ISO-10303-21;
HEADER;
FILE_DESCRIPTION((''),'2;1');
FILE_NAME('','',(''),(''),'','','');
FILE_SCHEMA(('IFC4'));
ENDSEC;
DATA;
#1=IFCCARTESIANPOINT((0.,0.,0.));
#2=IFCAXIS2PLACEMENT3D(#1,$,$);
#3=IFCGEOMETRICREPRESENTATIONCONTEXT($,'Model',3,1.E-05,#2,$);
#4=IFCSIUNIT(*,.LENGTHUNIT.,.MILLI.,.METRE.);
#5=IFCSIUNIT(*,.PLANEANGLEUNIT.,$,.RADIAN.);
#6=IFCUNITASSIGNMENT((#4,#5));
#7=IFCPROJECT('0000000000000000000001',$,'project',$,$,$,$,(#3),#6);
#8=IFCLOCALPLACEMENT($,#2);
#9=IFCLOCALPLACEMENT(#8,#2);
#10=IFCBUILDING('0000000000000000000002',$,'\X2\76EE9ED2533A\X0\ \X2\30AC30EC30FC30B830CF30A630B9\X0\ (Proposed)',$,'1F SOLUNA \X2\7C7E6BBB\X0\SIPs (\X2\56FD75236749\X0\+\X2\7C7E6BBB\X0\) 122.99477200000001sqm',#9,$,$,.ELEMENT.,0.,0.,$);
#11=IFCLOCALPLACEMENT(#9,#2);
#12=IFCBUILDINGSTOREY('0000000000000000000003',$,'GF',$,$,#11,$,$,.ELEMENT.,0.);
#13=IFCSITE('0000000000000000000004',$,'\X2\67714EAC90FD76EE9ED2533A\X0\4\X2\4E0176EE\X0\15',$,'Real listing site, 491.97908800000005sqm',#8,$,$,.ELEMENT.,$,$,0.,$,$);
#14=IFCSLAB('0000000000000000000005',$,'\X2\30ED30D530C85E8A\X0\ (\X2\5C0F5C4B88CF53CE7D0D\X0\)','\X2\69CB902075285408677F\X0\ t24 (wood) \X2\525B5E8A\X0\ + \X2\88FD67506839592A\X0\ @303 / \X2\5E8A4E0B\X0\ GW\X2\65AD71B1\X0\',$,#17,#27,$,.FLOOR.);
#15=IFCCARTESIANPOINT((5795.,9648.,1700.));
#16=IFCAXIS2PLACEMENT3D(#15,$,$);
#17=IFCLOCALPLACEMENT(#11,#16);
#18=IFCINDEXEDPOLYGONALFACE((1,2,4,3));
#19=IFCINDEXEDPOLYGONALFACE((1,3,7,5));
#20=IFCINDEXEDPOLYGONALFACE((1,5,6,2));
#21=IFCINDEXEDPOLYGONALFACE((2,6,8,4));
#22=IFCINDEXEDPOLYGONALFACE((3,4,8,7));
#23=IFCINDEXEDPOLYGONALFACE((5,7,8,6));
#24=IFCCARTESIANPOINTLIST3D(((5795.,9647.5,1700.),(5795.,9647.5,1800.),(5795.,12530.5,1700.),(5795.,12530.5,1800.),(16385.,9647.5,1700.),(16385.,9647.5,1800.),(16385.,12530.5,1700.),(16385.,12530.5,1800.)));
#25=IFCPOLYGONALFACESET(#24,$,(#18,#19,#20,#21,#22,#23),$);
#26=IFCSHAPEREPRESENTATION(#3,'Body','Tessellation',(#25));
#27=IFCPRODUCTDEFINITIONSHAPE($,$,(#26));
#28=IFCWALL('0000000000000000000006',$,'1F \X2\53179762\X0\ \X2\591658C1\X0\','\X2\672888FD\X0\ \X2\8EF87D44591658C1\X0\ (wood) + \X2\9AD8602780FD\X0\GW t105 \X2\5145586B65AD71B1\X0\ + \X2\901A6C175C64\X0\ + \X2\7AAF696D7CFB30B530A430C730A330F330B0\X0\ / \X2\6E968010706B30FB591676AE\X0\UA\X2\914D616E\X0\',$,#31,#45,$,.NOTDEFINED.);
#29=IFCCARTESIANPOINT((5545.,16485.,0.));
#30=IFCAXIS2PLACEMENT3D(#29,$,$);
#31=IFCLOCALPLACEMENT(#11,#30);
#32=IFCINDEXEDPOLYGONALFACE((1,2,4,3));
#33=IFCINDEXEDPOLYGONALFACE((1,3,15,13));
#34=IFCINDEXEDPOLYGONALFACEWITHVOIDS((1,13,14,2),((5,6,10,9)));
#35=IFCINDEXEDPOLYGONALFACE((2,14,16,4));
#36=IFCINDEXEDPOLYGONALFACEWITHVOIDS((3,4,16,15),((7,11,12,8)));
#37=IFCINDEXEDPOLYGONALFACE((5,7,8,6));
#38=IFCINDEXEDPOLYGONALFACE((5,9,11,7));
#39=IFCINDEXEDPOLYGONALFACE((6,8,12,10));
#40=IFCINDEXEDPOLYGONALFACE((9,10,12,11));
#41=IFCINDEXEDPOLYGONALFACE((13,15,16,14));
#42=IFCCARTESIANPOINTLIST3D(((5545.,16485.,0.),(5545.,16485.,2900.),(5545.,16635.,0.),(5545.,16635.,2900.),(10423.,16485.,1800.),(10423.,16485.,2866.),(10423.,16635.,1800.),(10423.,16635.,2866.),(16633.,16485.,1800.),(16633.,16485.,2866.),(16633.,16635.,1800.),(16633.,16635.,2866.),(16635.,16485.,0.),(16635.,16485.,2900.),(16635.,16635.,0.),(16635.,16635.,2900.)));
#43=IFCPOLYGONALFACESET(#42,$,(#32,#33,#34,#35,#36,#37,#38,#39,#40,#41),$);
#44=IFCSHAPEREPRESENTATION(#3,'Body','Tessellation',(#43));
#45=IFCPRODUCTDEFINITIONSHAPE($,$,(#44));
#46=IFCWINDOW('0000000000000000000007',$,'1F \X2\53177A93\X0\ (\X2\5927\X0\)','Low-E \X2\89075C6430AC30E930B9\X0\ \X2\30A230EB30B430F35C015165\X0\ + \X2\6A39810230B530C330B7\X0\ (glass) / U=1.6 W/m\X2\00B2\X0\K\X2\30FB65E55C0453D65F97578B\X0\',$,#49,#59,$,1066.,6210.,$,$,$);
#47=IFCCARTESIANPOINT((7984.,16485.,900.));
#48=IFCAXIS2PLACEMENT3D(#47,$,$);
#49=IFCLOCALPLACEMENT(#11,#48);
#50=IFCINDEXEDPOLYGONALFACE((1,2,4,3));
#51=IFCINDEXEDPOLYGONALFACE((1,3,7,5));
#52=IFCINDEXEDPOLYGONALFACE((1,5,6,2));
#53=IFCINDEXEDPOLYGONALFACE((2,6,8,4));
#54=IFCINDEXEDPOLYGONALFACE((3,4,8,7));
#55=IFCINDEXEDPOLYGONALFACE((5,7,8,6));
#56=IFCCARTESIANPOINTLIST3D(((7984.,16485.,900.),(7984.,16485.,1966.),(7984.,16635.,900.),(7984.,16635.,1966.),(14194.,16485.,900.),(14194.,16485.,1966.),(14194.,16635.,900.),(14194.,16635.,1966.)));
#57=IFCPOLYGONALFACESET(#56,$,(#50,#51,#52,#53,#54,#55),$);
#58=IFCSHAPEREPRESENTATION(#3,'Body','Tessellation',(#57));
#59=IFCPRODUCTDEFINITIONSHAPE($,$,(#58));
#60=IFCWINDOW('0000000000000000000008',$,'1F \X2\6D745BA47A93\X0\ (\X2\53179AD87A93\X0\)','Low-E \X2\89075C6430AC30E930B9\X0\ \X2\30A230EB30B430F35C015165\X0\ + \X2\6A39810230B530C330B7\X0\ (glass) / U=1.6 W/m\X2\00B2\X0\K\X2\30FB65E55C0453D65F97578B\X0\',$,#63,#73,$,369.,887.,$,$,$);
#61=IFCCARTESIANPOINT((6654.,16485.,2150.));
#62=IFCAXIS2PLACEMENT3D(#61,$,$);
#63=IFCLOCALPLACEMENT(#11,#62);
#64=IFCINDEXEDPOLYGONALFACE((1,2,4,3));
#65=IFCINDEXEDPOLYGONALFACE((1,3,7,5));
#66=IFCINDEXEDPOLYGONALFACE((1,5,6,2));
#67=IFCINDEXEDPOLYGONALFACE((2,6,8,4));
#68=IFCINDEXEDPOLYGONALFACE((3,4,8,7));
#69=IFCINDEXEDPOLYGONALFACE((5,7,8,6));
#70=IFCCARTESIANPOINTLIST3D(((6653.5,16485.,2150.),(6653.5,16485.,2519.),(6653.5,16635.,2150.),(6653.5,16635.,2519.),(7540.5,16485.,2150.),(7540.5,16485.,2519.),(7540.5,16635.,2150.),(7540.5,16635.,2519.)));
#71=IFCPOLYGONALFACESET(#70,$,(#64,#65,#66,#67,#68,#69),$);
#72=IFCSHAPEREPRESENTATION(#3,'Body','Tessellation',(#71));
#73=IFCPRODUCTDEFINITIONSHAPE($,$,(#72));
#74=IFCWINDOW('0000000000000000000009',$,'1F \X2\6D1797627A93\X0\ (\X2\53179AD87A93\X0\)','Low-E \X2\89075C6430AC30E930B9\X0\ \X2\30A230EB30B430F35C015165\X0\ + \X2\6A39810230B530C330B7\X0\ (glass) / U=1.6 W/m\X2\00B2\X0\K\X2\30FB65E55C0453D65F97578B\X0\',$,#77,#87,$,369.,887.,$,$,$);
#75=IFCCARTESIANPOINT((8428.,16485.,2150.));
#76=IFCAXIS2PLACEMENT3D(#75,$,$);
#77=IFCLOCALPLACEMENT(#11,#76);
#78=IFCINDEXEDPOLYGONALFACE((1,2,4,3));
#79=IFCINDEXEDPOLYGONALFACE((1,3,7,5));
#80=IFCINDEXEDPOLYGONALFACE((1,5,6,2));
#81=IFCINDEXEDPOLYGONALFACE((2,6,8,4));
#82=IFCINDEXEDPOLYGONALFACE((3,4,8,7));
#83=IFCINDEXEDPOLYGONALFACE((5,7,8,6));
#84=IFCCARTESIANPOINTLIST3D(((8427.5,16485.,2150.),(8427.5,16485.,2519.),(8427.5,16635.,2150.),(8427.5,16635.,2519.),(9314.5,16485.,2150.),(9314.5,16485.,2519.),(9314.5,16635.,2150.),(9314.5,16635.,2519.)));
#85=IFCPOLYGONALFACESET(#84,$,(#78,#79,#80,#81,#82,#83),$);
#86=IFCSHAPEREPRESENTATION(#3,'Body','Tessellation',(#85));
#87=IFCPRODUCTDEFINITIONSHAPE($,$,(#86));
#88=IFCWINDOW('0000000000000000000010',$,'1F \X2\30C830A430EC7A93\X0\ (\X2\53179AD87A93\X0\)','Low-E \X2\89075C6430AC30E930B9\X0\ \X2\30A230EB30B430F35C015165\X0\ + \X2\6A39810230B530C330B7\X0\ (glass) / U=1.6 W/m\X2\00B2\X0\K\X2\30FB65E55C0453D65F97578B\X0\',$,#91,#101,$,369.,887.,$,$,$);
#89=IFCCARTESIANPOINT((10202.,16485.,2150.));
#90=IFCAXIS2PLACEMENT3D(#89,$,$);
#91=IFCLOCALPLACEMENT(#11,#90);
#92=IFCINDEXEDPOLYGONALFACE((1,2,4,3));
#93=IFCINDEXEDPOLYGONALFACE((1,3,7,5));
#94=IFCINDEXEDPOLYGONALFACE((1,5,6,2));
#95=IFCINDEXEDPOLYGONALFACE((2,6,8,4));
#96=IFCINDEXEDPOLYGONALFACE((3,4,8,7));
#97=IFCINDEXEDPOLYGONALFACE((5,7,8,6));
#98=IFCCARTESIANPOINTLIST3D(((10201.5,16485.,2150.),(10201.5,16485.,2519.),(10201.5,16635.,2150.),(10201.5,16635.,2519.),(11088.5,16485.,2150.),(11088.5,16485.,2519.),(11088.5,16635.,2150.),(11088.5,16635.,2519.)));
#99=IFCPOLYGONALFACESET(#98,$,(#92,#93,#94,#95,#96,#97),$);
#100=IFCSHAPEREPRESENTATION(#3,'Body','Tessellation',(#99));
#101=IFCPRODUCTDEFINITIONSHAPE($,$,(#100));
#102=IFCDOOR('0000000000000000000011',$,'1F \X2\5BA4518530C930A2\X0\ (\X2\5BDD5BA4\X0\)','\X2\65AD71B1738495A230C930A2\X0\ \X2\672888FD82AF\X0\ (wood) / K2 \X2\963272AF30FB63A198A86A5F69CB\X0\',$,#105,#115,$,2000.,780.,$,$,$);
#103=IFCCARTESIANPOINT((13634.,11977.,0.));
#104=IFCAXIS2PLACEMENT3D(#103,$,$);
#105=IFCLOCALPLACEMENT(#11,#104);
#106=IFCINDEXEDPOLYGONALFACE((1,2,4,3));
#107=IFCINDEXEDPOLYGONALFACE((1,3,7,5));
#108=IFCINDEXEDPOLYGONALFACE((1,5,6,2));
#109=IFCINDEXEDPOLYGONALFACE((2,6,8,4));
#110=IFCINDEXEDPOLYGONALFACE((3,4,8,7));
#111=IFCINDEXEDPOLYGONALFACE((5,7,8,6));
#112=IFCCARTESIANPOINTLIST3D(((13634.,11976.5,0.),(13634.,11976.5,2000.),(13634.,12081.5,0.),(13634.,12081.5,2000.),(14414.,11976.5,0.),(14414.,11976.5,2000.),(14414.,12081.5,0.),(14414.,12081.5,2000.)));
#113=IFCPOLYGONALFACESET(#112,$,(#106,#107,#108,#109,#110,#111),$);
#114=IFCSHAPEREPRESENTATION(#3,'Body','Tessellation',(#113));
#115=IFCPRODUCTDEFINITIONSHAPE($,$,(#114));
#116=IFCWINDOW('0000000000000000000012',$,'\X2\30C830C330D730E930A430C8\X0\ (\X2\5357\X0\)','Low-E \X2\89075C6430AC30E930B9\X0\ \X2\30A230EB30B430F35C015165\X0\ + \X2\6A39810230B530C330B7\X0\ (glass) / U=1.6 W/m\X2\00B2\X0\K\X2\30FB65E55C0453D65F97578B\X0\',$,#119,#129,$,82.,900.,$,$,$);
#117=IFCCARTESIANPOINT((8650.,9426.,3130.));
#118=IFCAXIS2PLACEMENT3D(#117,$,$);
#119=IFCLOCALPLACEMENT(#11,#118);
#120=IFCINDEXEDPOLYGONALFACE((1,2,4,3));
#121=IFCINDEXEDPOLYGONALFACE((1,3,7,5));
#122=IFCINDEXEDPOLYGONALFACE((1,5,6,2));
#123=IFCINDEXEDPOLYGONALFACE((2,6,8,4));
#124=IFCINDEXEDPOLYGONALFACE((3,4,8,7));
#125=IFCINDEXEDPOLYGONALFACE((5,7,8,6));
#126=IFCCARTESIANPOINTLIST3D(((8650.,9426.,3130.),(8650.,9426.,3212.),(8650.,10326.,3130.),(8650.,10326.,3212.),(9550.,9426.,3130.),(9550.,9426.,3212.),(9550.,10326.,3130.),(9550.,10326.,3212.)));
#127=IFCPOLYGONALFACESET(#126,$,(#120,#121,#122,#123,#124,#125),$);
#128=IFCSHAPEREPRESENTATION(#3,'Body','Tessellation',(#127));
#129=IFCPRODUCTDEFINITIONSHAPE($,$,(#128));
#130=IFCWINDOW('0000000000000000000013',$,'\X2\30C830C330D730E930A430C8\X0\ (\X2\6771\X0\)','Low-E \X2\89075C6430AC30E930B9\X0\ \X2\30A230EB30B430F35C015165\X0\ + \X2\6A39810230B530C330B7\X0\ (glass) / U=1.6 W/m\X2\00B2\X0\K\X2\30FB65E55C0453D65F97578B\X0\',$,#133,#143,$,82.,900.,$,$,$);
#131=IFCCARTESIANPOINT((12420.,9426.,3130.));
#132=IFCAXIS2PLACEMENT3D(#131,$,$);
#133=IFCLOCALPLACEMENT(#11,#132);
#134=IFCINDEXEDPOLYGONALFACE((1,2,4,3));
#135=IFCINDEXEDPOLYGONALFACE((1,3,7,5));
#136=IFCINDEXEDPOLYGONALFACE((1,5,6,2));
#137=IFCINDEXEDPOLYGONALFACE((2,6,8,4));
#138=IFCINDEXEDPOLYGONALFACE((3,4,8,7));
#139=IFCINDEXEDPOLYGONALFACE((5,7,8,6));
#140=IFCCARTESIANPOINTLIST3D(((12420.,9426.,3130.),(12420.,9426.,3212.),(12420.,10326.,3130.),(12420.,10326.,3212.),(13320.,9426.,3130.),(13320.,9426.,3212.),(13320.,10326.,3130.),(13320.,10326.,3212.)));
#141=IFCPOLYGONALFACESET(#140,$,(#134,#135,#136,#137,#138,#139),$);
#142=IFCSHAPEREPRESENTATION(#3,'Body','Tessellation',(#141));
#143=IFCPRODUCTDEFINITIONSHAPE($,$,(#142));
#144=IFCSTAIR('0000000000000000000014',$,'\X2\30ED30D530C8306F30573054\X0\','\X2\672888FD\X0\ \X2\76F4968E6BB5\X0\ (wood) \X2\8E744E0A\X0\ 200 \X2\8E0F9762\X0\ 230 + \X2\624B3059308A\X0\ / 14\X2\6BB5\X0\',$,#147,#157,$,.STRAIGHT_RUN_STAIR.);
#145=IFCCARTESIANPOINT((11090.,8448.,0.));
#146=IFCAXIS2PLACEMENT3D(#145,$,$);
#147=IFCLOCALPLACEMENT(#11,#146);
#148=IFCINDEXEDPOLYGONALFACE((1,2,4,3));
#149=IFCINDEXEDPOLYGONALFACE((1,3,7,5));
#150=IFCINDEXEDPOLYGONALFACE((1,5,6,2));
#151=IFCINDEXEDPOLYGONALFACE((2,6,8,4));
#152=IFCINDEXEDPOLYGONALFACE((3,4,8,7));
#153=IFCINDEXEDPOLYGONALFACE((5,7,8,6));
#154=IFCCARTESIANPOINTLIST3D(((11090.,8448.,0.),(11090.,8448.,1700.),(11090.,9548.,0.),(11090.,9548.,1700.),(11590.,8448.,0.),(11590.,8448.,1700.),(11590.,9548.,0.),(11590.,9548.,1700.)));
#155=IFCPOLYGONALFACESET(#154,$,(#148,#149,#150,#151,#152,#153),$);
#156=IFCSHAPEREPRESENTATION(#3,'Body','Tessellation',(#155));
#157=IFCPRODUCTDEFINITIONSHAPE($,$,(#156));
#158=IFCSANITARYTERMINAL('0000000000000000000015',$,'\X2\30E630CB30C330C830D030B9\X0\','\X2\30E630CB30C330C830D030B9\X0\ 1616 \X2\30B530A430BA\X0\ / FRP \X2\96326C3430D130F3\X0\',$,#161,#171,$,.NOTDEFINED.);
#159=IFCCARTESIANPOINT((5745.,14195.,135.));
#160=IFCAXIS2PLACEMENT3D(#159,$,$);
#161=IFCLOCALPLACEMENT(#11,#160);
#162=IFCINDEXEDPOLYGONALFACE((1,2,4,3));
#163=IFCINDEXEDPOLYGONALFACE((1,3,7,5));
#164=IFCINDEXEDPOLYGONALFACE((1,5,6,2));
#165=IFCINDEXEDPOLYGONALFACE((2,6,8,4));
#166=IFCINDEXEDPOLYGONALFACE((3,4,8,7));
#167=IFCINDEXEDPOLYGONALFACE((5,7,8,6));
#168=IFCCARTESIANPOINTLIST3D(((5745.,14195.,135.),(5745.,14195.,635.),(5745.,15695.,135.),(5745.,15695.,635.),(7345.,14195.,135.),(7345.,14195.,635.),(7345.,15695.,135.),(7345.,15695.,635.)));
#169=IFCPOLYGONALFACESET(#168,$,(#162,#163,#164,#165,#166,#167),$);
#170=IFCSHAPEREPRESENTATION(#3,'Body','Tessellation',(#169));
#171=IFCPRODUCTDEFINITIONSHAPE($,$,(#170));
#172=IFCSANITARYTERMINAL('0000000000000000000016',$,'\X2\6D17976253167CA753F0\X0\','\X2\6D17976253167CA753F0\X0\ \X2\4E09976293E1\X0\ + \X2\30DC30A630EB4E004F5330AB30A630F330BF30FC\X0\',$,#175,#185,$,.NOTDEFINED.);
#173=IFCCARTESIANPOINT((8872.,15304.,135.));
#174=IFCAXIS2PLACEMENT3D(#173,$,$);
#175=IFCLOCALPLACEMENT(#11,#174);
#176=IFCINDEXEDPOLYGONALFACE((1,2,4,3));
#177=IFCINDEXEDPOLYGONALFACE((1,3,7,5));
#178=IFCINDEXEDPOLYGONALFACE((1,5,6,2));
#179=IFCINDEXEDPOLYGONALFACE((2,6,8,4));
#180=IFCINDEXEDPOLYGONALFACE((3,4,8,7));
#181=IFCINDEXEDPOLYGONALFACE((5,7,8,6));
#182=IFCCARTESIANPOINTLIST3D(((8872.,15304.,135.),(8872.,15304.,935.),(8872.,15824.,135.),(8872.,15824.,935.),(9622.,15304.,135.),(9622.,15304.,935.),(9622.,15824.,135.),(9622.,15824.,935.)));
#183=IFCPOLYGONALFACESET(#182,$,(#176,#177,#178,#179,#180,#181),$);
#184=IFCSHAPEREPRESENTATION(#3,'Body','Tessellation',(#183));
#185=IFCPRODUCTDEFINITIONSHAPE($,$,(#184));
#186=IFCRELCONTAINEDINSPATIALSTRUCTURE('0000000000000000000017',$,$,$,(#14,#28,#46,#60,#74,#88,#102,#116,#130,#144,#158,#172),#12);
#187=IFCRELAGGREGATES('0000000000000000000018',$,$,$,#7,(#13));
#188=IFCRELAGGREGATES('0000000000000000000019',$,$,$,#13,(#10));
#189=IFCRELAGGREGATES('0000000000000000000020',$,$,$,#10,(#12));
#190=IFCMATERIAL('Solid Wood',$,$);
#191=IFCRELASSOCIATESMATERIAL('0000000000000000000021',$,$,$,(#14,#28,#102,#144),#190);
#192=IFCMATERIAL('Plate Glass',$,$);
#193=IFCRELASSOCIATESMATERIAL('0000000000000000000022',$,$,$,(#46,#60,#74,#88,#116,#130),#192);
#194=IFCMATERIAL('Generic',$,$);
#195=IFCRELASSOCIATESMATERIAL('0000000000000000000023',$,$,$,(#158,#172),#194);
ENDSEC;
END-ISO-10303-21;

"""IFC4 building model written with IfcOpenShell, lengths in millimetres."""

from ifc_helpers import new_model, si_unit, frame, frame_2d, origin, place, context, project, spatial, rectangle, extrude, material, element, fill, save


model = new_model("IFC4")

# Units and contexts
model_context = context("Model", 3, precision=1e-05, world=origin())
ifc_project = project(units=[si_unit("LENGTHUNIT", "METRE", prefix="MILLI"), si_unit("PLANEANGLEUNIT", "RADIAN")], contexts=[model_context])

# Site, building, storey
site_placement = place(None, origin())
site = spatial("IfcSite", under=ifc_project, at=site_placement, Name="東京都目黒区4丁目15", ObjectType="Real listing site, 491.97908800000005sqm", CompositionType="ELEMENT", RefElevation=0.0)
building_placement = place(site_placement, origin())
building = spatial("IfcBuilding", under=site, at=building_placement, Name="目黒区 ガレージハウス (Proposed)", ObjectType="1F SOLUNA 籾殻SIPs (国産杉+籾殻) 122.99477200000001sqm", CompositionType="ELEMENT", ElevationOfRefHeight=0.0, ElevationOfTerrain=0.0)
storey_placement = place(building_placement, origin())
storey = spatial("IfcBuildingStorey", under=building, at=storey_placement, Name="GF", CompositionType="ELEMENT", Elevation=0.0)

# Slab
ifc_material_1 = material(Name="Solid Wood")
slab_placement = place(storey_placement, frame((5795.0, 9648.0, 1700.0)))
element("IfcSlab", 1, at=slab_placement, inside=storey, material=ifc_material_1, Name="ロフト床 (小屋裏収納)", Description="構造用合板 t24 (wood) 剛床 + 製材根太 @303 / 床下 GW断熱", PredefinedType="FLOOR", context=model_context, shape_type="SweptSolid", body=[
    extrude(rectangle(XDim=10590.0, YDim=2883.0, at=frame_2d((5295.0, 1441.0))), frame((5795.0, 9648.0, 1700.0)), (0.0, 0.0, 1.0), 100.0),
])

# Wall, openings, windows
wall_1_placement = place(storey_placement, frame((5545.0, 16485.0, 0.0)))
wall_1 = element("IfcWall", 2, at=wall_1_placement, inside=storey, material=ifc_material_1, Name="1F 北面 外壁", Description="木製 軸組外壁 (wood) + 高性能GW t105 充填断熱 + 通気層 + 窯業系サイディング / 準耐火・外皮UA配慮", PredefinedType="NOTDEFINED", context=model_context, shape_type="SweptSolid", body=[
    extrude(rectangle(XDim=11090.0, YDim=150.0, at=frame_2d((5545.0, 75.0))), frame((5545.0, 16485.0, 0.0)), (0.0, 0.0, 1.0), 2900.0),
])
opening_1_placement = place(storey_placement, frame((7984.0, 16485.0, 900.0)))
opening_1 = element("IfcOpeningElement", 3, at=opening_1_placement, cuts=wall_1, PredefinedType="NOTDEFINED", context=model_context, shape_type="SweptSolid", body=[
    extrude(rectangle(XDim=6210.0, YDim=150.0, at=frame_2d((3105.0, 75.0))), frame((7984.0, 16485.0, 900.0)), (0.0, 0.0, 1.0), 1066.0),
])
opening_2_placement = place(storey_placement, frame((6654.0, 16485.0, 2150.0)))
opening_2 = element("IfcOpeningElement", 4, at=opening_2_placement, cuts=wall_1, PredefinedType="NOTDEFINED", context=model_context, shape_type="SweptSolid", body=[
    extrude(rectangle(XDim=887.0, YDim=150.0, at=frame_2d((443.0, 75.0))), frame((6654.0, 16485.0, 2150.0)), (0.0, 0.0, 1.0), 369.0),
])
opening_3_placement = place(storey_placement, frame((8428.0, 16485.0, 2150.0)))
opening_3 = element("IfcOpeningElement", 5, at=opening_3_placement, cuts=wall_1, PredefinedType="NOTDEFINED", context=model_context, shape_type="SweptSolid", body=[
    extrude(rectangle(XDim=887.0, YDim=150.0, at=frame_2d((443.0, 75.0))), frame((8428.0, 16485.0, 2150.0)), (0.0, 0.0, 1.0), 369.0),
])
opening_4_placement = place(storey_placement, frame((10202.0, 16485.0, 2150.0)))
opening_4 = element("IfcOpeningElement", 6, at=opening_4_placement, cuts=wall_1, PredefinedType="NOTDEFINED", context=model_context, shape_type="SweptSolid", body=[
    extrude(rectangle(XDim=887.0, YDim=150.0, at=frame_2d((443.0, 75.0))), frame((10202.0, 16485.0, 2150.0)), (0.0, 0.0, 1.0), 369.0),
])
ifc_material_2 = material(Name="Plate Glass")
window_1_placement = place(storey_placement, frame((7984.0, 16485.0, 900.0)))
window_1 = element("IfcWindow", 7, at=window_1_placement, inside=storey, material=ifc_material_2, Name="1F 北窓 (大)", Description="Low-E 複層ガラス アルゴン封入 + 樹脂サッシ (glass) / U=1.6 W/m²K・日射取得型", OverallHeight=1066.0, OverallWidth=6210.0, context=model_context, shape_type="SweptSolid", body=[
    extrude(rectangle(XDim=6210.0, YDim=150.0, at=frame_2d((3105.0, 75.0))), frame((7984.0, 16485.0, 900.0)), (0.0, 0.0, 1.0), 1066.0),
])
fill(opening_1, window_1)
window_2_placement = place(storey_placement, frame((6654.0, 16485.0, 2150.0)))
window_2 = element("IfcWindow", 8, at=window_2_placement, inside=storey, material=ifc_material_2, Name="1F 浴室窓 (北高窓)", Description="Low-E 複層ガラス アルゴン封入 + 樹脂サッシ (glass) / U=1.6 W/m²K・日射取得型", OverallHeight=369.0, OverallWidth=887.0, context=model_context, shape_type="SweptSolid", body=[
    extrude(rectangle(XDim=887.0, YDim=150.0, at=frame_2d((443.0, 75.0))), frame((6654.0, 16485.0, 2150.0)), (0.0, 0.0, 1.0), 369.0),
])
fill(opening_2, window_2)
window_3_placement = place(storey_placement, frame((8428.0, 16485.0, 2150.0)))
window_3 = element("IfcWindow", 9, at=window_3_placement, inside=storey, material=ifc_material_2, Name="1F 洗面窓 (北高窓)", Description="Low-E 複層ガラス アルゴン封入 + 樹脂サッシ (glass) / U=1.6 W/m²K・日射取得型", OverallHeight=369.0, OverallWidth=887.0, context=model_context, shape_type="SweptSolid", body=[
    extrude(rectangle(XDim=887.0, YDim=150.0, at=frame_2d((443.0, 75.0))), frame((8428.0, 16485.0, 2150.0)), (0.0, 0.0, 1.0), 369.0),
])
fill(opening_3, window_3)
window_4_placement = place(storey_placement, frame((10202.0, 16485.0, 2150.0)))
window_4 = element("IfcWindow", 10, at=window_4_placement, inside=storey, material=ifc_material_2, Name="1F トイレ窓 (北高窓)", Description="Low-E 複層ガラス アルゴン封入 + 樹脂サッシ (glass) / U=1.6 W/m²K・日射取得型", OverallHeight=369.0, OverallWidth=887.0, context=model_context, shape_type="SweptSolid", body=[
    extrude(rectangle(XDim=887.0, YDim=150.0, at=frame_2d((443.0, 75.0))), frame((10202.0, 16485.0, 2150.0)), (0.0, 0.0, 1.0), 369.0),
])
fill(opening_4, window_4)

# Door
door_1_placement = place(storey_placement, frame((13634.0, 11977.0, 0.0)))
element("IfcDoor", 11, at=door_1_placement, inside=storey, material=ifc_material_1, Name="1F 室内ドア (寝室)", Description="断熱玄関ドア 木製芯 (wood) / K2 防犯・採風機構", OverallHeight=2000.0, OverallWidth=780.0, context=model_context, shape_type="SweptSolid", body=[
    extrude(rectangle(XDim=780.0, YDim=105.0, at=frame_2d((390.0, 52.0))), frame((13634.0, 11977.0, 0.0)), (0.0, 0.0, 1.0), 2000.0),
])

# Windows
window_5_placement = place(storey_placement, frame((8650.0, 9426.0, 3130.0)))
element("IfcWindow", 12, at=window_5_placement, inside=storey, material=ifc_material_2, Name="トップライト (南)", Description="Low-E 複層ガラス アルゴン封入 + 樹脂サッシ (glass) / U=1.6 W/m²K・日射取得型", OverallHeight=82.0, OverallWidth=900.0, context=model_context, shape_type="SweptSolid", body=[
    extrude(rectangle(XDim=900.0, YDim=900.0, at=frame_2d((450.0, 450.0))), frame((8650.0, 9426.0, 3130.0)), (0.0, 0.0, 1.0), 82.0),
])
window_6_placement = place(storey_placement, frame((12420.0, 9426.0, 3130.0)))
element("IfcWindow", 13, at=window_6_placement, inside=storey, material=ifc_material_2, Name="トップライト (東)", Description="Low-E 複層ガラス アルゴン封入 + 樹脂サッシ (glass) / U=1.6 W/m²K・日射取得型", OverallHeight=82.0, OverallWidth=900.0, context=model_context, shape_type="SweptSolid", body=[
    extrude(rectangle(XDim=900.0, YDim=900.0, at=frame_2d((450.0, 450.0))), frame((12420.0, 9426.0, 3130.0)), (0.0, 0.0, 1.0), 82.0),
])

# Stair
stair_placement = place(storey_placement, frame((11090.0, 8448.0, 0.0)))
element("IfcStair", 14, at=stair_placement, inside=storey, material=ifc_material_1, Name="ロフトはしご", Description="木製 直階段 (wood) 蹴上 200 踏面 230 + 手すり / 14段", PredefinedType="STRAIGHT_RUN_STAIR", context=model_context, shape_type="SweptSolid", body=[
    extrude(rectangle(XDim=500.0, YDim=1100.0, at=frame_2d((250.0, 550.0))), frame((11090.0, 8448.0, 0.0)), (0.0, 0.0, 1.0), 1700.0),
])

# Sanitary terminals
ifc_material_3 = material(Name="Generic")
sanitary_terminal_1_placement = place(storey_placement, frame((5745.0, 14195.0, 135.0)))
element("IfcSanitaryTerminal", 15, at=sanitary_terminal_1_placement, inside=storey, material=ifc_material_3, Name="ユニットバス", Description="ユニットバス 1616 サイズ / FRP 防水パン", PredefinedType="NOTDEFINED", context=model_context, shape_type="SweptSolid", body=[
    extrude(rectangle(XDim=1600.0, YDim=1500.0, at=frame_2d((800.0, 750.0))), frame((5745.0, 14195.0, 135.0)), (0.0, 0.0, 1.0), 500.0),
])
sanitary_terminal_2_placement = place(storey_placement, frame((8872.0, 15304.0, 135.0)))
element("IfcSanitaryTerminal", 16, at=sanitary_terminal_2_placement, inside=storey, material=ifc_material_3, Name="洗面化粧台", Description="洗面化粧台 三面鏡 + ボウル一体カウンター", PredefinedType="NOTDEFINED", context=model_context, shape_type="SweptSolid", body=[
    extrude(rectangle(XDim=750.0, YDim=520.0, at=frame_2d((375.0, 260.0))), frame((8872.0, 15304.0, 135.0)), (0.0, 0.0, 1.0), 800.0),
])

save(model, "model.ifc")
